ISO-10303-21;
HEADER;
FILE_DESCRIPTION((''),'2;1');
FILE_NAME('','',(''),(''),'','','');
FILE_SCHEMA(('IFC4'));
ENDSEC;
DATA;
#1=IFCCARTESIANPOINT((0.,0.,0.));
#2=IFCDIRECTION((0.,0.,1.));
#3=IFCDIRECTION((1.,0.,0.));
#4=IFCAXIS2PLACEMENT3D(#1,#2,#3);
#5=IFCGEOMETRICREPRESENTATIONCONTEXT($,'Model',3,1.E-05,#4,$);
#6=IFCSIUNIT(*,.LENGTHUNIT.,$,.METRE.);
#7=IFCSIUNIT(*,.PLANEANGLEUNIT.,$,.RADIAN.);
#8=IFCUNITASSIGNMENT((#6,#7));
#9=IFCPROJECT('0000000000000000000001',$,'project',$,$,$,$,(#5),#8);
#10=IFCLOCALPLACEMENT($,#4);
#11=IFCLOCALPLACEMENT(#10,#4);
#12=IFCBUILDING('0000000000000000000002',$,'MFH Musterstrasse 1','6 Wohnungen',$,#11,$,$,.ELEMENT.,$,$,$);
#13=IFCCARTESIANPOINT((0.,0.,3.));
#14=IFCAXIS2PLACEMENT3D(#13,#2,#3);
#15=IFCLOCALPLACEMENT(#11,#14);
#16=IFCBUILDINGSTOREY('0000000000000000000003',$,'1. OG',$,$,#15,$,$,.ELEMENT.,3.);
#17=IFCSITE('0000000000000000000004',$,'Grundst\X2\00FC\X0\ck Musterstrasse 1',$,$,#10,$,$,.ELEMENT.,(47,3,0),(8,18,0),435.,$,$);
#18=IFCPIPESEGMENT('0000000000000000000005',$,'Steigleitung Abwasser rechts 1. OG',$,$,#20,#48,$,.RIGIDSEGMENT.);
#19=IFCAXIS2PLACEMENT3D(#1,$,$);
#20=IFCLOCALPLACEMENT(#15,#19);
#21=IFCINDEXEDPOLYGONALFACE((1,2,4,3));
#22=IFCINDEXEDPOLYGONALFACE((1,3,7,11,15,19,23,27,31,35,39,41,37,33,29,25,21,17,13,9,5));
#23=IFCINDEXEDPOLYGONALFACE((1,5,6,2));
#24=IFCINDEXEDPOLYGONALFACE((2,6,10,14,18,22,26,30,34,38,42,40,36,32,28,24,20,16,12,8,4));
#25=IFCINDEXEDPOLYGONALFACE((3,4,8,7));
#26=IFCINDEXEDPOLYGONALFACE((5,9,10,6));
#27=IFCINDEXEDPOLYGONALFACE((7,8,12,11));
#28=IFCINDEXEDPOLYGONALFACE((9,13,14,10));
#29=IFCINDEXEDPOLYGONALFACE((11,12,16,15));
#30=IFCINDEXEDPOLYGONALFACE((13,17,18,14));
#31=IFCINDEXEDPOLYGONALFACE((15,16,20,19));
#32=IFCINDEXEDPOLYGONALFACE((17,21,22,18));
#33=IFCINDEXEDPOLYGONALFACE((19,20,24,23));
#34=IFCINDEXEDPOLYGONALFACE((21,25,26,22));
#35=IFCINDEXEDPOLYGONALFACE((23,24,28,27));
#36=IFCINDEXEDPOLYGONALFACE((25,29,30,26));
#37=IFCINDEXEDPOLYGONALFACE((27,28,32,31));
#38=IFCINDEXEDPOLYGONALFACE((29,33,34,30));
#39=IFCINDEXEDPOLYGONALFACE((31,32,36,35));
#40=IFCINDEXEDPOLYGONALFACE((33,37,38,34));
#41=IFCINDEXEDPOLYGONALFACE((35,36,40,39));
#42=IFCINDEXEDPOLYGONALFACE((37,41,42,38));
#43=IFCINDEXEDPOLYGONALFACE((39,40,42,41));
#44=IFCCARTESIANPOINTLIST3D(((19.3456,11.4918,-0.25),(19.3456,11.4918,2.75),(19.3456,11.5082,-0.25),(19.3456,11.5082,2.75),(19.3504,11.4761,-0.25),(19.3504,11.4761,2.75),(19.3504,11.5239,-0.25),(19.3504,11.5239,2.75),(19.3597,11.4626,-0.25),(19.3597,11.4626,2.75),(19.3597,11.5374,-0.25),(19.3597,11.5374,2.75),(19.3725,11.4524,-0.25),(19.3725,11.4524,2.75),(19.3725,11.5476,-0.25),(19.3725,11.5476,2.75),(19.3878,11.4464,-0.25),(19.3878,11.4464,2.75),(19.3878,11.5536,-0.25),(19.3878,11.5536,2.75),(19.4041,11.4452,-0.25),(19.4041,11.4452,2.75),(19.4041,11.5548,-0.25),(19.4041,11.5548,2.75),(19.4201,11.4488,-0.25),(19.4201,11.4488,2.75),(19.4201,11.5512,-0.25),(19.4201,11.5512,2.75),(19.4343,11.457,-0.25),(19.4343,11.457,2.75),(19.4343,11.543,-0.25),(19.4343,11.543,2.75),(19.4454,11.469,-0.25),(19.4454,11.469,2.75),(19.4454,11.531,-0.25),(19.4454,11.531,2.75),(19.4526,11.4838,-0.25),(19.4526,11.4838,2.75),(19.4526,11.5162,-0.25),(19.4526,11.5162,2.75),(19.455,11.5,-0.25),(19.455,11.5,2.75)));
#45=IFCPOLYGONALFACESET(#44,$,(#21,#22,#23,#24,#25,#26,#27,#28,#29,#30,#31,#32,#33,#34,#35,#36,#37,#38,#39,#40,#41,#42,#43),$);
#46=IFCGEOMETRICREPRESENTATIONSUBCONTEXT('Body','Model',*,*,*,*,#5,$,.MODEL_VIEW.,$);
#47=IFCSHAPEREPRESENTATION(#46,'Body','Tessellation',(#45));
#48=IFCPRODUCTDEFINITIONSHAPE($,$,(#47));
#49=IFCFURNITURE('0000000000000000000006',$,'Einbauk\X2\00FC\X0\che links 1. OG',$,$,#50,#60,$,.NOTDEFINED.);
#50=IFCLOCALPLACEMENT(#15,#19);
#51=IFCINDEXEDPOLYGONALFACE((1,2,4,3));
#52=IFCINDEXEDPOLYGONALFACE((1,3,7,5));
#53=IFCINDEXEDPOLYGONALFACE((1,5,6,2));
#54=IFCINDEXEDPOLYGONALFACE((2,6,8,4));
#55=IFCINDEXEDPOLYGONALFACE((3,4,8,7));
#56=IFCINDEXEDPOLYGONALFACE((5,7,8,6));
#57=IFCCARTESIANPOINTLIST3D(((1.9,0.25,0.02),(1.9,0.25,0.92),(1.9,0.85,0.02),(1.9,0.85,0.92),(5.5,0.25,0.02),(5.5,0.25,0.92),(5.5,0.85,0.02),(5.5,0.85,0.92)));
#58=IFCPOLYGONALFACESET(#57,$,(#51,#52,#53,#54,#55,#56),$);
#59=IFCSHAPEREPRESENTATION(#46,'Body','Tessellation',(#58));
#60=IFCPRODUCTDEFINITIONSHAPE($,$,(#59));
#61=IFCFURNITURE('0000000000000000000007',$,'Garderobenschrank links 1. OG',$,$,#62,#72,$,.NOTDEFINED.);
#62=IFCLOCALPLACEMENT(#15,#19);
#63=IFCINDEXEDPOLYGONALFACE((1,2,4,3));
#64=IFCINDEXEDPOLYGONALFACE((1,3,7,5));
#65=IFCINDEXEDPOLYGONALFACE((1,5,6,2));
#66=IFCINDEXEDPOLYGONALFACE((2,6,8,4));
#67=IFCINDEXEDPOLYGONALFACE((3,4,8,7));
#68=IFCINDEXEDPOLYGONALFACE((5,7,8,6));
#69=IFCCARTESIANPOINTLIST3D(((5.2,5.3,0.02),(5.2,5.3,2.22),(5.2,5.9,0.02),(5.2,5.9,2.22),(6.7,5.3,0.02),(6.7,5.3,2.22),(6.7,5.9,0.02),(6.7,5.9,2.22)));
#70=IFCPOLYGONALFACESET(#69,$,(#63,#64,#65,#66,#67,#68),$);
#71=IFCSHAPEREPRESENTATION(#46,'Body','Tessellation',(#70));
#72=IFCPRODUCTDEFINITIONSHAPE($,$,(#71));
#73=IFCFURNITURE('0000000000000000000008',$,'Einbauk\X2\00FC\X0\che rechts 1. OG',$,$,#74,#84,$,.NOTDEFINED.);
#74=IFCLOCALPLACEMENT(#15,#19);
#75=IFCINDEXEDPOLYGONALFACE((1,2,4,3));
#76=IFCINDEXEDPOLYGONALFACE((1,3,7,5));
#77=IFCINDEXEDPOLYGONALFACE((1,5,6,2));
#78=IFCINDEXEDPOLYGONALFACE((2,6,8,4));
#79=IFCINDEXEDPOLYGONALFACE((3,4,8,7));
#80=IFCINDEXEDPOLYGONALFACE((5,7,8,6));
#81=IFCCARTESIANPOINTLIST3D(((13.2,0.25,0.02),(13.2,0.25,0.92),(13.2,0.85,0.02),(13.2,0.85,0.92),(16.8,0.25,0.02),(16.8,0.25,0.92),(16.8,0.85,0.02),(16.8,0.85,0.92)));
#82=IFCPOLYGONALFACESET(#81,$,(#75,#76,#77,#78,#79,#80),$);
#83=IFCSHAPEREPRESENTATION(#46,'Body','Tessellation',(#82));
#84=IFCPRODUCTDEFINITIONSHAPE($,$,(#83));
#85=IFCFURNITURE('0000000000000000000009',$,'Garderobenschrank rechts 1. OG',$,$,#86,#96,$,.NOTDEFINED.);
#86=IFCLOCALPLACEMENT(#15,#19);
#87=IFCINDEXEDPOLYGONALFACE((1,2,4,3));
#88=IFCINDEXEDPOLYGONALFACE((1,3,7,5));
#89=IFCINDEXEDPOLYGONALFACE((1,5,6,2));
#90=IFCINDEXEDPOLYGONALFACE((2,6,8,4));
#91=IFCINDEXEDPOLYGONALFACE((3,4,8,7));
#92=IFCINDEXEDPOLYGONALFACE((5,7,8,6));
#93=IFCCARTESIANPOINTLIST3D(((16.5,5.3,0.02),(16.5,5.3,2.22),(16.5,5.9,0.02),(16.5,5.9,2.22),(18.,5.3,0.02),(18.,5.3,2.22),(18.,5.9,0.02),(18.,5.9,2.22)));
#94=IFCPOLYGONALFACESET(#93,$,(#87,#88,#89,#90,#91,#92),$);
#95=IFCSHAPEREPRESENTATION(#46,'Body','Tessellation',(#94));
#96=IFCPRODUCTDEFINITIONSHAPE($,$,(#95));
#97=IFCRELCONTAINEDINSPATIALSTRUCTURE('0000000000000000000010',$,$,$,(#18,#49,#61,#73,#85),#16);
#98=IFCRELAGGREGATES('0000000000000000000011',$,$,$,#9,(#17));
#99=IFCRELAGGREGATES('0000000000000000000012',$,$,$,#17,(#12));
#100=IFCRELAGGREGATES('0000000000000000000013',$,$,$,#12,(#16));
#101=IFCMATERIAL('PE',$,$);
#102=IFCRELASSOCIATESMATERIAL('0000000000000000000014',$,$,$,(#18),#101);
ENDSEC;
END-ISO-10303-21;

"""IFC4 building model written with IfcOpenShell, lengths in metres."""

from ifc_helpers import new_model, si_unit, frame, frame_2d, origin_with_axes, origin_2d_with_axis, place, context, subcontext, project, spatial, rectangle, circle, extrude, material, element, save


model = new_model("IFC4")

# Units and contexts
model_context = context("Model", 3, precision=1e-05, world=origin_with_axes())
body_context = subcontext(model_context, "Body", "Model", "MODEL_VIEW")
ifc_project = project(units=[si_unit("LENGTHUNIT", "METRE"), si_unit("PLANEANGLEUNIT", "RADIAN")], contexts=[model_context])

# Site, building, storey
site_placement = place(None, origin_with_axes())
site = spatial("IfcSite", under=ifc_project, at=site_placement, Name="Grundstück Musterstrasse 1", CompositionType="ELEMENT", RefLatitude=(47, 3, 0), RefLongitude=(8, 18, 0), RefElevation=435.0)
building_placement = place(site_placement, origin_with_axes())
building = spatial("IfcBuilding", under=site, at=building_placement, Name="MFH Musterstrasse 1", Description="6 Wohnungen", CompositionType="ELEMENT")
storey_placement = place(building_placement, frame((0.0, 0.0, 3.0), z_axis=(0.0, 0.0, 1.0), x_axis=(1.0, 0.0, 0.0)))
storey = spatial("IfcBuildingStorey", under=building, at=storey_placement, Name="1. OG", CompositionType="ELEMENT", Elevation=3.0)

# Shared definitions
ifc_material_1 = material(Name="PE")

# Pipe segment
pipe_segment_1_placement = place(storey_placement, origin_with_axes())
element("IfcPipeSegment", 1, at=pipe_segment_1_placement, inside=storey, material=ifc_material_1, Name="Steigleitung Abwasser rechts 1. OG", PredefinedType="RIGIDSEGMENT", context=body_context, shape_type="SweptSolid", body=[
    extrude(circle(Radius=0.055, at=origin_2d_with_axis()), frame((19.4, 11.5, -0.25), z_axis=(0.0, 0.0, 1.0), x_axis=(1.0, 0.0, 0.0)), (0.0, 0.0, 1.0), 3.0),
])

# Furniture
furniture_1_placement = place(storey_placement, origin_with_axes())
element("IfcFurniture", 2, at=furniture_1_placement, inside=storey, Name="Einbauküche links 1. OG", PredefinedType="NOTDEFINED", context=body_context, shape_type="SweptSolid", body=[
    extrude(rectangle(XDim=3.6, YDim=0.6, at=frame_2d((1.8, 0.3), x_axis=(1.0, 0.0))), frame((1.9, 0.25, 0.02), z_axis=(0.0, 0.0, 1.0), x_axis=(1.0, 0.0, 0.0)), (0.0, 0.0, 1.0), 0.9),
])
furniture_2_placement = place(storey_placement, origin_with_axes())
element("IfcFurniture", 3, at=furniture_2_placement, inside=storey, Name="Garderobenschrank links 1. OG", PredefinedType="NOTDEFINED", context=body_context, shape_type="SweptSolid", body=[
    extrude(rectangle(XDim=1.5, YDim=0.6, at=frame_2d((0.75, 0.3), x_axis=(1.0, 0.0))), frame((5.2, 5.3, 0.02), z_axis=(0.0, 0.0, 1.0), x_axis=(1.0, 0.0, 0.0)), (0.0, 0.0, 1.0), 2.2),
])
furniture_3_placement = place(storey_placement, origin_with_axes())
element("IfcFurniture", 4, at=furniture_3_placement, inside=storey, Name="Einbauküche rechts 1. OG", PredefinedType="NOTDEFINED", context=body_context, shape_type="SweptSolid", body=[
    extrude(rectangle(XDim=3.6, YDim=0.6, at=frame_2d((1.8, 0.3), x_axis=(1.0, 0.0))), frame((13.2, 0.25, 0.02), z_axis=(0.0, 0.0, 1.0), x_axis=(1.0, 0.0, 0.0)), (0.0, 0.0, 1.0), 0.9),
])
furniture_4_placement = place(storey_placement, origin_with_axes())
element("IfcFurniture", 5, at=furniture_4_placement, inside=storey, Name="Garderobenschrank rechts 1. OG", PredefinedType="NOTDEFINED", context=body_context, shape_type="SweptSolid", body=[
    extrude(rectangle(XDim=1.5, YDim=0.6, at=frame_2d((0.75, 0.3), x_axis=(1.0, 0.0))), frame((16.5, 5.3, 0.02), z_axis=(0.0, 0.0, 1.0), x_axis=(1.0, 0.0, 0.0)), (0.0, 0.0, 1.0), 2.2),
])

save(model, "model.ifc")
